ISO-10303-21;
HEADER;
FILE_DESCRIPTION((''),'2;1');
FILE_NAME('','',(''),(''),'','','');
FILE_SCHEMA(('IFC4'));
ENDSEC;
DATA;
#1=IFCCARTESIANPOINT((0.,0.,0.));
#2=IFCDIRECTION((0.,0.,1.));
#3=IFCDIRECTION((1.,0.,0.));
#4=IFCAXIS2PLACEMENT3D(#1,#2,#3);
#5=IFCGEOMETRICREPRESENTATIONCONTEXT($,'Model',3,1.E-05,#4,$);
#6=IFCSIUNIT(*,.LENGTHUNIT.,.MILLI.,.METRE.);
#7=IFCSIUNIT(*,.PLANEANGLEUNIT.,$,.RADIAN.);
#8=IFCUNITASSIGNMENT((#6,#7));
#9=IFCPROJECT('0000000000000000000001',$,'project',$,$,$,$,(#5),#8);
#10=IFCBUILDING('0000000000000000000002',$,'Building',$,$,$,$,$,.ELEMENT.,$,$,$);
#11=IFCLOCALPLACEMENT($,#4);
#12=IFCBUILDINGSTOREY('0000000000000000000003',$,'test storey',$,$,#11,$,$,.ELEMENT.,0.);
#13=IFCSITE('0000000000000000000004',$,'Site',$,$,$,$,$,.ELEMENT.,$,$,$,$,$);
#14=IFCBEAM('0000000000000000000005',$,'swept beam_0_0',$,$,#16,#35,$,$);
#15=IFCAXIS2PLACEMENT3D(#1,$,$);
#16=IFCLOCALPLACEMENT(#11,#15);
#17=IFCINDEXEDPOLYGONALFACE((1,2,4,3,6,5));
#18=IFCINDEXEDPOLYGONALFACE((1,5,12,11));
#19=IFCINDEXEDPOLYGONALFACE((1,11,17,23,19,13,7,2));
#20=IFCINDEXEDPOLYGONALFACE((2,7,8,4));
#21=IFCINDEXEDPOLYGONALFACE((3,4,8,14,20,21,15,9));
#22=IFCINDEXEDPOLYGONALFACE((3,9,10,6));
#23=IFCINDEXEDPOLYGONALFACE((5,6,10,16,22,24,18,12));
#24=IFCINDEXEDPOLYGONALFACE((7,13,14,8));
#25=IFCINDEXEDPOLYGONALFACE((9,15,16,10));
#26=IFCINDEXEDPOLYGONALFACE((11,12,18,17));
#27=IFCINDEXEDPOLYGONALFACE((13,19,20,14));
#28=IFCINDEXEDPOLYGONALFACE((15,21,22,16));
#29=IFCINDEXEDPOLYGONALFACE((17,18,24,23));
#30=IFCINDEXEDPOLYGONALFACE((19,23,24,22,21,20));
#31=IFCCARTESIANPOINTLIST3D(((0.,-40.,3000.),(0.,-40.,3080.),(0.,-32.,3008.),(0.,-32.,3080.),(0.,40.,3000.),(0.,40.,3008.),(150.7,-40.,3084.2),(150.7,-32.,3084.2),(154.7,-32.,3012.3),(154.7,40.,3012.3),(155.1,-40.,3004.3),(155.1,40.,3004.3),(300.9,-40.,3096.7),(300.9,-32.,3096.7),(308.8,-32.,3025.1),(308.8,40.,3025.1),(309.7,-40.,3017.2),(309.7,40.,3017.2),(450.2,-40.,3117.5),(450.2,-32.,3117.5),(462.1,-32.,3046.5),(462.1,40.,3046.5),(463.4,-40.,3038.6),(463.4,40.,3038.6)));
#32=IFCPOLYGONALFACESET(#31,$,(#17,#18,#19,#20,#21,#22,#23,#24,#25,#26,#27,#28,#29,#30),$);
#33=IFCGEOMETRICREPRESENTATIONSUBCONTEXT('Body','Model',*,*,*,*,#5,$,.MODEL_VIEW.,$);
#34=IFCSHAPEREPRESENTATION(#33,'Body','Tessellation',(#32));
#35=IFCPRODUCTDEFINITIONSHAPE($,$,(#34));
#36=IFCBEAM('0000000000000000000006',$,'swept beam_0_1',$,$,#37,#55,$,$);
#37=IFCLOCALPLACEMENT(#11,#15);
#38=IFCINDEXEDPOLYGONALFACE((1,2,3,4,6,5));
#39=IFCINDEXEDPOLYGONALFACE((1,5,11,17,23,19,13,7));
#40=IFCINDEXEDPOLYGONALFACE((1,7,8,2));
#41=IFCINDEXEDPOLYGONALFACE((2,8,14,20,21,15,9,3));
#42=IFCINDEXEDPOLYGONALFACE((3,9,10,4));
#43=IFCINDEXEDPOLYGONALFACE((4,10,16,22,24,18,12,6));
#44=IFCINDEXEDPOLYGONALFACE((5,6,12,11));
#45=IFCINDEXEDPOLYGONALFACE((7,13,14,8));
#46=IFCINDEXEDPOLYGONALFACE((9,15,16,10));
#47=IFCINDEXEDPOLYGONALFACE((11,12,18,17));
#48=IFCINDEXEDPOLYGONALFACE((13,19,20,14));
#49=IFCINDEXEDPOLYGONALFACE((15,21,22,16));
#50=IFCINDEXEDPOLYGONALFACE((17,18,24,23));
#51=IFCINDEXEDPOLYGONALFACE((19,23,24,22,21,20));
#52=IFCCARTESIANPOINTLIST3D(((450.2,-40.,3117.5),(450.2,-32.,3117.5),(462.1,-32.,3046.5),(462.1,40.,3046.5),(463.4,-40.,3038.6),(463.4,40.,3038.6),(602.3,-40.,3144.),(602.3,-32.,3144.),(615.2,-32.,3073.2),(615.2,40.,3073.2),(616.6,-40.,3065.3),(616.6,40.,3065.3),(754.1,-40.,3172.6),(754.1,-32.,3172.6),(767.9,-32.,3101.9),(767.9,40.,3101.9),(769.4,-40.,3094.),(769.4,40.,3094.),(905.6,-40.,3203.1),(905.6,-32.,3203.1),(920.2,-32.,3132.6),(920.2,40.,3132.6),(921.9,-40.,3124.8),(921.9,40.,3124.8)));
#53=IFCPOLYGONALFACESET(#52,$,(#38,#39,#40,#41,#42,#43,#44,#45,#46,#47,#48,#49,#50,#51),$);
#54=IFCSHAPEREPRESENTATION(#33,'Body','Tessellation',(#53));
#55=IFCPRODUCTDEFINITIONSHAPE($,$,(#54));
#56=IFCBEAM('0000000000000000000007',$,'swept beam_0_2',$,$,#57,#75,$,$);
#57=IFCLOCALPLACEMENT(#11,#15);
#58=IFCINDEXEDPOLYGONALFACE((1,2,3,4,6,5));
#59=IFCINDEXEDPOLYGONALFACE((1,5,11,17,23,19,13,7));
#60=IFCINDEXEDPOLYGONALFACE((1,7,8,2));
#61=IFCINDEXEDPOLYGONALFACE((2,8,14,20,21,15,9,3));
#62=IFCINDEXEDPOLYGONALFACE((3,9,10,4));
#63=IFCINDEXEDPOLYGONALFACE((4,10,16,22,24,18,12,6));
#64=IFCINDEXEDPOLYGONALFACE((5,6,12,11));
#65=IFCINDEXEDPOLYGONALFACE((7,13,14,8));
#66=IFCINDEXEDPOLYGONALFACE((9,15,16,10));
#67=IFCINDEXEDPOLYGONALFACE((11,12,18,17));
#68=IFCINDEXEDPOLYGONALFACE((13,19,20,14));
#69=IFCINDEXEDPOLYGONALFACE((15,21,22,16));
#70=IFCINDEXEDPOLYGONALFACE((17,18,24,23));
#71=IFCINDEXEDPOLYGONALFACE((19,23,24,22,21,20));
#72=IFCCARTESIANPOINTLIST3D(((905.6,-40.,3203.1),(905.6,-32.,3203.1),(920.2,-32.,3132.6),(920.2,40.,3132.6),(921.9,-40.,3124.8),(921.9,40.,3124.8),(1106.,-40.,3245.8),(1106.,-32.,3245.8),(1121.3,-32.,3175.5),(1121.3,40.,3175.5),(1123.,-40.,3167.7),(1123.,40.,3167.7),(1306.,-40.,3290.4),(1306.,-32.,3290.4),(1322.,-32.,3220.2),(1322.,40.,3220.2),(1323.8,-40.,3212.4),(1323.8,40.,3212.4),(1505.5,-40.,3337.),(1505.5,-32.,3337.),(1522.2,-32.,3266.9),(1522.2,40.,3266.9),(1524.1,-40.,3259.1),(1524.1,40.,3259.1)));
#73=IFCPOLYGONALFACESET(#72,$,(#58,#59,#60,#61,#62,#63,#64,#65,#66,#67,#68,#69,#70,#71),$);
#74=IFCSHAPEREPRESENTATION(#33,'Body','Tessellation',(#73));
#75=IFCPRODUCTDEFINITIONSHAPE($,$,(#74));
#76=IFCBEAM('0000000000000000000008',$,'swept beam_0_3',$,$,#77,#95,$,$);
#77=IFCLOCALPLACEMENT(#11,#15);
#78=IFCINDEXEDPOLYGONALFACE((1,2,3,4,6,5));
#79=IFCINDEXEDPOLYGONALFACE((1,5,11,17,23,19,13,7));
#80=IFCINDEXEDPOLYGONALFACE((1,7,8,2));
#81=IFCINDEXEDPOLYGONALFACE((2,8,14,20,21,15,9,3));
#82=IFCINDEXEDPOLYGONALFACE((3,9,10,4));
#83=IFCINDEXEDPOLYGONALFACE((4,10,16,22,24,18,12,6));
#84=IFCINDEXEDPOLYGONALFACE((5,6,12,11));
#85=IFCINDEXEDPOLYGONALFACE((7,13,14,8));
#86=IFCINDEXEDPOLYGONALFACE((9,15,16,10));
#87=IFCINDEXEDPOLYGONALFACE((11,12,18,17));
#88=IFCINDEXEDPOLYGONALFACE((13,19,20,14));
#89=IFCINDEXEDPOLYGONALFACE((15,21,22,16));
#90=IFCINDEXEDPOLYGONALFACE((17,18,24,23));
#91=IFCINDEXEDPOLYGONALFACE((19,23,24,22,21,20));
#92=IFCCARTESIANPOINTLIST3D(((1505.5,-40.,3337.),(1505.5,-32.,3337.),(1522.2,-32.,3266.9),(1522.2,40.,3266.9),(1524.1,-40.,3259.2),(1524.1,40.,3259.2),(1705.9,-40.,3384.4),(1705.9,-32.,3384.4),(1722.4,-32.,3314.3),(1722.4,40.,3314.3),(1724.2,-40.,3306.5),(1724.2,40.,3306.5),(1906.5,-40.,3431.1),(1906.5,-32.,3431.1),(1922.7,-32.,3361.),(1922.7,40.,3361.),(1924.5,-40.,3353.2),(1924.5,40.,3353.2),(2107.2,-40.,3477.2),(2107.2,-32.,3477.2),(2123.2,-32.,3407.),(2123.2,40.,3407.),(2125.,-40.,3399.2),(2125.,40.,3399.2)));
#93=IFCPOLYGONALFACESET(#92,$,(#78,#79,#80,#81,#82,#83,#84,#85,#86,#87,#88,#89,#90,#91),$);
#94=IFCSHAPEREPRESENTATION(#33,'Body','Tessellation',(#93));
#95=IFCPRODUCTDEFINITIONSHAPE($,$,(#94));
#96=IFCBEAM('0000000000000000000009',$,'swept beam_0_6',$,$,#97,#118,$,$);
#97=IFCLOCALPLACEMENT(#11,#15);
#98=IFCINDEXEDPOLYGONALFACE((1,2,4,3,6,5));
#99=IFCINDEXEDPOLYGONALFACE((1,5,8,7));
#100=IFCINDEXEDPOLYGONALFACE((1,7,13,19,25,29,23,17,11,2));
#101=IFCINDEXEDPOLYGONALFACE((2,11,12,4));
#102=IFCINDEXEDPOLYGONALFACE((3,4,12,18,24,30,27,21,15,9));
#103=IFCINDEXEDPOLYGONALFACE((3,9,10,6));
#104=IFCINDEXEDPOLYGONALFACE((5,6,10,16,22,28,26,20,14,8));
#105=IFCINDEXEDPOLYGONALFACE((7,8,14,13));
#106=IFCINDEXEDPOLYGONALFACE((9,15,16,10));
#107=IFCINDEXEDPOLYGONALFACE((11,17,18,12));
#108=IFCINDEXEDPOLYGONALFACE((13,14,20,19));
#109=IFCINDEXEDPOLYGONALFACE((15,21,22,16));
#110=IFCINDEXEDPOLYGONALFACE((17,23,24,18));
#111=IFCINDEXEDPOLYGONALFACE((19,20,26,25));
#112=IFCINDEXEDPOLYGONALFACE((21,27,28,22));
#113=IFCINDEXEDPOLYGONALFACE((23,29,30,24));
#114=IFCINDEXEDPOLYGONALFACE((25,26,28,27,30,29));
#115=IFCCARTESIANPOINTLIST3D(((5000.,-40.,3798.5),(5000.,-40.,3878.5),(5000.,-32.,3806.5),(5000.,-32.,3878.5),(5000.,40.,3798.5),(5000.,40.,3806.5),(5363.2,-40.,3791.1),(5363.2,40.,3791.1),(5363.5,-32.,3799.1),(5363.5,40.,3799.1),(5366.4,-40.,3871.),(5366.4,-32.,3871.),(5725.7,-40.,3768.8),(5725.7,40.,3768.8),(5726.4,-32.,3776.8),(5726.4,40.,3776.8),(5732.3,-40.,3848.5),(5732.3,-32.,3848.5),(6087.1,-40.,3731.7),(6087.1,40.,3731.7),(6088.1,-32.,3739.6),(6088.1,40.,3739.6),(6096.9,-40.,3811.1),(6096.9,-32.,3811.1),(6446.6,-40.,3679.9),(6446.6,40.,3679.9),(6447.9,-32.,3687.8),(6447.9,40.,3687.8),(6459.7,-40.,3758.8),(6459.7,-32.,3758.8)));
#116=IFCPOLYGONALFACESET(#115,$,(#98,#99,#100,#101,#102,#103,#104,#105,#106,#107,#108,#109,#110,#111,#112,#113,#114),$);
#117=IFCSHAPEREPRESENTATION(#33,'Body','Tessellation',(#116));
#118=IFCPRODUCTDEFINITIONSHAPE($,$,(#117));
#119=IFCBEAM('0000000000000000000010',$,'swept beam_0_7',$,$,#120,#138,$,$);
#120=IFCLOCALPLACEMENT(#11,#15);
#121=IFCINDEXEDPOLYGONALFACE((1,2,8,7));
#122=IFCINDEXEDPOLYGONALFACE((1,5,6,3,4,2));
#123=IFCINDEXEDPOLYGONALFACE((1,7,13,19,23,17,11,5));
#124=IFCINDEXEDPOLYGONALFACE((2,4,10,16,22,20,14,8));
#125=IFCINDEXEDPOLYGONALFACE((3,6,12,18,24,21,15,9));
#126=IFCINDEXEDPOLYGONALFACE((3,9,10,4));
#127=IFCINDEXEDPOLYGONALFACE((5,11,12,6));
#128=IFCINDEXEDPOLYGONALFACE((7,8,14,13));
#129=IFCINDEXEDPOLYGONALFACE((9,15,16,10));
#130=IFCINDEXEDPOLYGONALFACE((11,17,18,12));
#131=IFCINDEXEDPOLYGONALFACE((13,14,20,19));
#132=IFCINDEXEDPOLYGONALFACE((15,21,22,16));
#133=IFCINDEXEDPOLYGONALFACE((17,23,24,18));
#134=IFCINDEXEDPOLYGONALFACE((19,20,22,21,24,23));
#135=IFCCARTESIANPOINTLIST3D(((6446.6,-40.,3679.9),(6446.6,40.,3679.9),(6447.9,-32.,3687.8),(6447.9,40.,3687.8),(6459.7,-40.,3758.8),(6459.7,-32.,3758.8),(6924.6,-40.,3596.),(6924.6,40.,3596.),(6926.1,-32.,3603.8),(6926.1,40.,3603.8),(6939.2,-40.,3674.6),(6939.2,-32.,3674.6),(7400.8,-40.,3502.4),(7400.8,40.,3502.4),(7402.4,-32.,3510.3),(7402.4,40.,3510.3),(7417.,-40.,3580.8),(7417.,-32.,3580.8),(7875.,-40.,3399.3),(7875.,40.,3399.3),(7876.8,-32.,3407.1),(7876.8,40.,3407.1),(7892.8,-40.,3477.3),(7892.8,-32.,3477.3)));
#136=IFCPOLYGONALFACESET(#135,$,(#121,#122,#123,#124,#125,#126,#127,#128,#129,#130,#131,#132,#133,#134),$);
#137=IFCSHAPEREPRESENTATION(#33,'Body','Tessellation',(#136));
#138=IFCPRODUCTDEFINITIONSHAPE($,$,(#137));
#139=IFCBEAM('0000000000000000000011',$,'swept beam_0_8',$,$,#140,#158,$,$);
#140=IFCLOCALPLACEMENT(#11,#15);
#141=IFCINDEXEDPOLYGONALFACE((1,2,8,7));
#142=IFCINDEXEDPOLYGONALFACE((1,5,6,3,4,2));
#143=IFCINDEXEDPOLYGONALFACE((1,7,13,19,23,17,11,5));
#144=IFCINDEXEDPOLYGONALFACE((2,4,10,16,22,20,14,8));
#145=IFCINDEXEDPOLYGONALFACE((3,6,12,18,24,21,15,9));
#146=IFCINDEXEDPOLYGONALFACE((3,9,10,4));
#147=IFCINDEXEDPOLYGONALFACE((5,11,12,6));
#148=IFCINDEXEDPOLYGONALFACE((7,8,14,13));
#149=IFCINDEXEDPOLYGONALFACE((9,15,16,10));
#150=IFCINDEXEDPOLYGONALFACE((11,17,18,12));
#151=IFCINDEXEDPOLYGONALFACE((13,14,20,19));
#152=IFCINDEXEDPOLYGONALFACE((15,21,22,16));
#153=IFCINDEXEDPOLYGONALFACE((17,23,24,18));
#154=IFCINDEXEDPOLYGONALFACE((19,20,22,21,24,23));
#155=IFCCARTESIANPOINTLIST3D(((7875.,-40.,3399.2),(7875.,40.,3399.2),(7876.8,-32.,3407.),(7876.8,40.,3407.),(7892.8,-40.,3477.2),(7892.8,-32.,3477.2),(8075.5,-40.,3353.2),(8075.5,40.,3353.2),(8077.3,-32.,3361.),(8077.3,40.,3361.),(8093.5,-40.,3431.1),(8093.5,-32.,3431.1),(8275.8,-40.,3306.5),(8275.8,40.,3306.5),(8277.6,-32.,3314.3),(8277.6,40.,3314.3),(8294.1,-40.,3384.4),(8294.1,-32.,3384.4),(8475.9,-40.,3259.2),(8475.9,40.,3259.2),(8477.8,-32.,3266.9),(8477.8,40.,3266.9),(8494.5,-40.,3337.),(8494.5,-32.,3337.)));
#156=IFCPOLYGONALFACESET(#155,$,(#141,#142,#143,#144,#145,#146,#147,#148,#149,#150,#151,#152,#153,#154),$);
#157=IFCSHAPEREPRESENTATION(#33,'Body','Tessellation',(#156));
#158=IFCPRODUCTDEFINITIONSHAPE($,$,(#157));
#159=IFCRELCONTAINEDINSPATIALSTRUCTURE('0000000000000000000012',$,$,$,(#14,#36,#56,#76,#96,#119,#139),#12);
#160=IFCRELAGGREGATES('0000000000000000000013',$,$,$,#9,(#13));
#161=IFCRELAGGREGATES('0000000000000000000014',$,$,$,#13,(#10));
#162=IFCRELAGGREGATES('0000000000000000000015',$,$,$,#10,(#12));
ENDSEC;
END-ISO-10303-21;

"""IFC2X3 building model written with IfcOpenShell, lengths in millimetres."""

from ifc_helpers import new_model, entity, si_unit, origin_with_axes, place, context, subcontext, project, spatial, element, save


model = new_model("IFC2X3")

# Units and contexts
model_context = context("Model", 3, precision=1e-05, world=origin_with_axes())
body_context = subcontext(model_context, "Body", "Model", "MODEL_VIEW")
ifc_project = project(units=[si_unit("LENGTHUNIT", "METRE", prefix="MILLI"), si_unit("PLANEANGLEUNIT", "RADIAN")], contexts=[model_context])

# Site, building, storey
site = spatial("IfcSite", under=ifc_project, Name="Site", CompositionType="ELEMENT")
building = spatial("IfcBuilding", under=site, Name="Building", CompositionType="ELEMENT")
storey_placement = place(None, origin_with_axes())
storey = spatial("IfcBuildingStorey", under=building, at=storey_placement, Name="test storey", CompositionType="ELEMENT", Elevation=0.0)

# Beams
beam_1_placement = place(storey_placement, origin_with_axes())
element("IfcBeam", 1, at=beam_1_placement, inside=storey, Name="swept beam_0_0", context=body_context, shape_type="SweptSolid", body=[
    entity("IfcRevolvedAreaSolid", entity("IfcArbitraryClosedProfileDef", "AREA", None, entity("IfcPolyline", [entity("IfcCartesianPoint", [-80.0, 40.0]), entity("IfcCartesianPoint", [-80.0, 32.0]), entity("IfcCartesianPoint", [-8.0, 32.0]), entity("IfcCartesianPoint", [-8.0, -40.0]), entity("IfcCartesianPoint", [0.0, -40.0]), entity("IfcCartesianPoint", [0.0, 40.0]), entity("IfcCartesianPoint", [-80.0, 40.0])])), entity("IfcAxis2Placement3D", entity("IfcCartesianPoint", [0.0, 0.0, 3000.0]), entity("IfcDirection", [-1.0, 0.0, 0.0]), entity("IfcDirection", [0.0, 0.0, -1.0])), entity("IfcAxis1Placement", entity("IfcCartesianPoint", [-2801.2, 0.0, 0.0]), entity("IfcDirection", [0.0, 1.0, 0.0])), 0.166192),
])
beam_2_placement = place(storey_placement, origin_with_axes())
element("IfcBeam", 2, at=beam_2_placement, inside=storey, Name="swept beam_0_1", context=body_context, shape_type="SweptSolid", body=[
    entity("IfcRevolvedAreaSolid", entity("IfcArbitraryClosedProfileDef", "AREA", None, entity("IfcPolyline", [entity("IfcCartesianPoint", [-80.0, 40.0]), entity("IfcCartesianPoint", [-80.0, 32.0]), entity("IfcCartesianPoint", [-8.0, 32.0]), entity("IfcCartesianPoint", [-8.0, -40.0]), entity("IfcCartesianPoint", [0.0, -40.0]), entity("IfcCartesianPoint", [0.0, 40.0]), entity("IfcCartesianPoint", [-80.0, 40.0])])), entity("IfcAxis2Placement3D", entity("IfcCartesianPoint", [463.4, 0.0, 3038.6]), entity("IfcDirection", [-0.9862, 0.0, -0.1654]), entity("IfcDirection", [0.1654, 0.0, -0.9862])), entity("IfcAxis1Placement", entity("IfcCartesianPoint", [-11908.9, 0.0, 0.0]), entity("IfcDirection", [0.0, 1.0, 0.0])), 0.039176),
])
beam_3_placement = place(storey_placement, origin_with_axes())
element("IfcBeam", 3, at=beam_3_placement, inside=storey, Name="swept beam_0_2", context=body_context, shape_type="SweptSolid", body=[
    entity("IfcRevolvedAreaSolid", entity("IfcArbitraryClosedProfileDef", "AREA", None, entity("IfcPolyline", [entity("IfcCartesianPoint", [-80.0, 40.0]), entity("IfcCartesianPoint", [-80.0, 32.0]), entity("IfcCartesianPoint", [-8.0, 32.0]), entity("IfcCartesianPoint", [-8.0, -40.0]), entity("IfcCartesianPoint", [0.0, -40.0]), entity("IfcCartesianPoint", [0.0, 40.0]), entity("IfcCartesianPoint", [-80.0, 40.0])])), entity("IfcAxis2Placement3D", entity("IfcCartesianPoint", [921.9, 0.0, 3124.8]), entity("IfcDirection", [-0.979, 0.0, -0.2039]), entity("IfcDirection", [0.2039, 0.0, -0.979])), entity("IfcAxis1Placement", entity("IfcCartesianPoint", [-21723.0, 0.0, 0.0]), entity("IfcDirection", [0.0, 1.0, 0.0])), 0.028404),
])
beam_4_placement = place(storey_placement, origin_with_axes())
element("IfcBeam", 4, at=beam_4_placement, inside=storey, Name="swept beam_0_3", context=body_context, shape_type="SweptSolid", body=[
    entity("IfcRevolvedAreaSolid", entity("IfcArbitraryClosedProfileDef", "AREA", None, entity("IfcPolyline", [entity("IfcCartesianPoint", [80.0, -40.0]), entity("IfcCartesianPoint", [80.0, -32.0]), entity("IfcCartesianPoint", [8.0, -32.0]), entity("IfcCartesianPoint", [8.0, 40.0]), entity("IfcCartesianPoint", [0.0, 40.0]), entity("IfcCartesianPoint", [0.0, -40.0]), entity("IfcCartesianPoint", [80.0, -40.0])])), entity("IfcAxis2Placement3D", entity("IfcCartesianPoint", [1524.1, 0.0, 3259.2]), entity("IfcDirection", [-0.9728, 0.0, -0.2316]), entity("IfcDirection", [-0.2316, 0.0, 0.9728])), entity("IfcAxis1Placement", entity("IfcCartesianPoint", [-65174.9, 0.0, 0.0]), entity("IfcDirection", [0.0, 1.0, 0.0])), 0.009468),
])
beam_5_placement = place(storey_placement, origin_with_axes())
element("IfcBeam", 5, at=beam_5_placement, inside=storey, Name="swept beam_0_6", context=body_context, shape_type="SweptSolid", body=[
    entity("IfcRevolvedAreaSolid", entity("IfcArbitraryClosedProfileDef", "AREA", None, entity("IfcPolyline", [entity("IfcCartesianPoint", [80.0, -40.0]), entity("IfcCartesianPoint", [80.0, -32.0]), entity("IfcCartesianPoint", [8.0, -32.0]), entity("IfcCartesianPoint", [8.0, 40.0]), entity("IfcCartesianPoint", [0.0, 40.0]), entity("IfcCartesianPoint", [0.0, -40.0]), entity("IfcCartesianPoint", [80.0, -40.0])])), entity("IfcAxis2Placement3D", entity("IfcCartesianPoint", [5000.0, 0.0, 3798.5]), entity("IfcDirection", [-1.0, 0.0, 0.0]), entity("IfcDirection", [0.0, 0.0, 1.0])), entity("IfcAxis1Placement", entity("IfcCartesianPoint", [-8878.8, 0.0, 0.0]), entity("IfcDirection", [0.0, 1.0, 0.0])), 0.16366),
])
beam_6_placement = place(storey_placement, origin_with_axes())
element("IfcBeam", 6, at=beam_6_placement, inside=storey, Name="swept beam_0_7", context=body_context, shape_type="SweptSolid", body=[
    entity("IfcRevolvedAreaSolid", entity("IfcArbitraryClosedProfileDef", "AREA", None, entity("IfcPolyline", [entity("IfcCartesianPoint", [80.0, -40.0]), entity("IfcCartesianPoint", [80.0, -32.0]), entity("IfcCartesianPoint", [8.0, -32.0]), entity("IfcCartesianPoint", [8.0, 40.0]), entity("IfcCartesianPoint", [0.0, 40.0]), entity("IfcCartesianPoint", [0.0, -40.0]), entity("IfcCartesianPoint", [80.0, -40.0])])), entity("IfcAxis2Placement3D", entity("IfcCartesianPoint", [6446.6, 0.0, 3679.9]), entity("IfcDirection", [-0.9866, 0.0, 0.1629]), entity("IfcDirection", [0.1629, 0.0, 0.9866])), entity("IfcAxis1Placement", entity("IfcCartesianPoint", [-24007.4, 0.0, 0.0]), entity("IfcDirection", [0.0, 1.0, 0.0])), 0.060644),
])
beam_7_placement = place(storey_placement, origin_with_axes())
element("IfcBeam", 7, at=beam_7_placement, inside=storey, Name="swept beam_0_8", context=body_context, shape_type="SweptSolid", body=[
    entity("IfcRevolvedAreaSolid", entity("IfcArbitraryClosedProfileDef", "AREA", None, entity("IfcPolyline", [entity("IfcCartesianPoint", [80.0, -40.0]), entity("IfcCartesianPoint", [80.0, -32.0]), entity("IfcCartesianPoint", [8.0, -32.0]), entity("IfcCartesianPoint", [8.0, 40.0]), entity("IfcCartesianPoint", [0.0, 40.0]), entity("IfcCartesianPoint", [0.0, -40.0]), entity("IfcCartesianPoint", [80.0, -40.0])])), entity("IfcAxis2Placement3D", entity("IfcCartesianPoint", [7875.0, 0.0, 3399.2]), entity("IfcDirection", [-0.9749, 0.0, 0.2224]), entity("IfcDirection", [0.2224, 0.0, 0.9749])), entity("IfcAxis1Placement", entity("IfcCartesianPoint", [-65174.9, 0.0, 0.0]), entity("IfcDirection", [0.0, 1.0, 0.0])), 0.009468),
])

save(model, "model.ifc")
